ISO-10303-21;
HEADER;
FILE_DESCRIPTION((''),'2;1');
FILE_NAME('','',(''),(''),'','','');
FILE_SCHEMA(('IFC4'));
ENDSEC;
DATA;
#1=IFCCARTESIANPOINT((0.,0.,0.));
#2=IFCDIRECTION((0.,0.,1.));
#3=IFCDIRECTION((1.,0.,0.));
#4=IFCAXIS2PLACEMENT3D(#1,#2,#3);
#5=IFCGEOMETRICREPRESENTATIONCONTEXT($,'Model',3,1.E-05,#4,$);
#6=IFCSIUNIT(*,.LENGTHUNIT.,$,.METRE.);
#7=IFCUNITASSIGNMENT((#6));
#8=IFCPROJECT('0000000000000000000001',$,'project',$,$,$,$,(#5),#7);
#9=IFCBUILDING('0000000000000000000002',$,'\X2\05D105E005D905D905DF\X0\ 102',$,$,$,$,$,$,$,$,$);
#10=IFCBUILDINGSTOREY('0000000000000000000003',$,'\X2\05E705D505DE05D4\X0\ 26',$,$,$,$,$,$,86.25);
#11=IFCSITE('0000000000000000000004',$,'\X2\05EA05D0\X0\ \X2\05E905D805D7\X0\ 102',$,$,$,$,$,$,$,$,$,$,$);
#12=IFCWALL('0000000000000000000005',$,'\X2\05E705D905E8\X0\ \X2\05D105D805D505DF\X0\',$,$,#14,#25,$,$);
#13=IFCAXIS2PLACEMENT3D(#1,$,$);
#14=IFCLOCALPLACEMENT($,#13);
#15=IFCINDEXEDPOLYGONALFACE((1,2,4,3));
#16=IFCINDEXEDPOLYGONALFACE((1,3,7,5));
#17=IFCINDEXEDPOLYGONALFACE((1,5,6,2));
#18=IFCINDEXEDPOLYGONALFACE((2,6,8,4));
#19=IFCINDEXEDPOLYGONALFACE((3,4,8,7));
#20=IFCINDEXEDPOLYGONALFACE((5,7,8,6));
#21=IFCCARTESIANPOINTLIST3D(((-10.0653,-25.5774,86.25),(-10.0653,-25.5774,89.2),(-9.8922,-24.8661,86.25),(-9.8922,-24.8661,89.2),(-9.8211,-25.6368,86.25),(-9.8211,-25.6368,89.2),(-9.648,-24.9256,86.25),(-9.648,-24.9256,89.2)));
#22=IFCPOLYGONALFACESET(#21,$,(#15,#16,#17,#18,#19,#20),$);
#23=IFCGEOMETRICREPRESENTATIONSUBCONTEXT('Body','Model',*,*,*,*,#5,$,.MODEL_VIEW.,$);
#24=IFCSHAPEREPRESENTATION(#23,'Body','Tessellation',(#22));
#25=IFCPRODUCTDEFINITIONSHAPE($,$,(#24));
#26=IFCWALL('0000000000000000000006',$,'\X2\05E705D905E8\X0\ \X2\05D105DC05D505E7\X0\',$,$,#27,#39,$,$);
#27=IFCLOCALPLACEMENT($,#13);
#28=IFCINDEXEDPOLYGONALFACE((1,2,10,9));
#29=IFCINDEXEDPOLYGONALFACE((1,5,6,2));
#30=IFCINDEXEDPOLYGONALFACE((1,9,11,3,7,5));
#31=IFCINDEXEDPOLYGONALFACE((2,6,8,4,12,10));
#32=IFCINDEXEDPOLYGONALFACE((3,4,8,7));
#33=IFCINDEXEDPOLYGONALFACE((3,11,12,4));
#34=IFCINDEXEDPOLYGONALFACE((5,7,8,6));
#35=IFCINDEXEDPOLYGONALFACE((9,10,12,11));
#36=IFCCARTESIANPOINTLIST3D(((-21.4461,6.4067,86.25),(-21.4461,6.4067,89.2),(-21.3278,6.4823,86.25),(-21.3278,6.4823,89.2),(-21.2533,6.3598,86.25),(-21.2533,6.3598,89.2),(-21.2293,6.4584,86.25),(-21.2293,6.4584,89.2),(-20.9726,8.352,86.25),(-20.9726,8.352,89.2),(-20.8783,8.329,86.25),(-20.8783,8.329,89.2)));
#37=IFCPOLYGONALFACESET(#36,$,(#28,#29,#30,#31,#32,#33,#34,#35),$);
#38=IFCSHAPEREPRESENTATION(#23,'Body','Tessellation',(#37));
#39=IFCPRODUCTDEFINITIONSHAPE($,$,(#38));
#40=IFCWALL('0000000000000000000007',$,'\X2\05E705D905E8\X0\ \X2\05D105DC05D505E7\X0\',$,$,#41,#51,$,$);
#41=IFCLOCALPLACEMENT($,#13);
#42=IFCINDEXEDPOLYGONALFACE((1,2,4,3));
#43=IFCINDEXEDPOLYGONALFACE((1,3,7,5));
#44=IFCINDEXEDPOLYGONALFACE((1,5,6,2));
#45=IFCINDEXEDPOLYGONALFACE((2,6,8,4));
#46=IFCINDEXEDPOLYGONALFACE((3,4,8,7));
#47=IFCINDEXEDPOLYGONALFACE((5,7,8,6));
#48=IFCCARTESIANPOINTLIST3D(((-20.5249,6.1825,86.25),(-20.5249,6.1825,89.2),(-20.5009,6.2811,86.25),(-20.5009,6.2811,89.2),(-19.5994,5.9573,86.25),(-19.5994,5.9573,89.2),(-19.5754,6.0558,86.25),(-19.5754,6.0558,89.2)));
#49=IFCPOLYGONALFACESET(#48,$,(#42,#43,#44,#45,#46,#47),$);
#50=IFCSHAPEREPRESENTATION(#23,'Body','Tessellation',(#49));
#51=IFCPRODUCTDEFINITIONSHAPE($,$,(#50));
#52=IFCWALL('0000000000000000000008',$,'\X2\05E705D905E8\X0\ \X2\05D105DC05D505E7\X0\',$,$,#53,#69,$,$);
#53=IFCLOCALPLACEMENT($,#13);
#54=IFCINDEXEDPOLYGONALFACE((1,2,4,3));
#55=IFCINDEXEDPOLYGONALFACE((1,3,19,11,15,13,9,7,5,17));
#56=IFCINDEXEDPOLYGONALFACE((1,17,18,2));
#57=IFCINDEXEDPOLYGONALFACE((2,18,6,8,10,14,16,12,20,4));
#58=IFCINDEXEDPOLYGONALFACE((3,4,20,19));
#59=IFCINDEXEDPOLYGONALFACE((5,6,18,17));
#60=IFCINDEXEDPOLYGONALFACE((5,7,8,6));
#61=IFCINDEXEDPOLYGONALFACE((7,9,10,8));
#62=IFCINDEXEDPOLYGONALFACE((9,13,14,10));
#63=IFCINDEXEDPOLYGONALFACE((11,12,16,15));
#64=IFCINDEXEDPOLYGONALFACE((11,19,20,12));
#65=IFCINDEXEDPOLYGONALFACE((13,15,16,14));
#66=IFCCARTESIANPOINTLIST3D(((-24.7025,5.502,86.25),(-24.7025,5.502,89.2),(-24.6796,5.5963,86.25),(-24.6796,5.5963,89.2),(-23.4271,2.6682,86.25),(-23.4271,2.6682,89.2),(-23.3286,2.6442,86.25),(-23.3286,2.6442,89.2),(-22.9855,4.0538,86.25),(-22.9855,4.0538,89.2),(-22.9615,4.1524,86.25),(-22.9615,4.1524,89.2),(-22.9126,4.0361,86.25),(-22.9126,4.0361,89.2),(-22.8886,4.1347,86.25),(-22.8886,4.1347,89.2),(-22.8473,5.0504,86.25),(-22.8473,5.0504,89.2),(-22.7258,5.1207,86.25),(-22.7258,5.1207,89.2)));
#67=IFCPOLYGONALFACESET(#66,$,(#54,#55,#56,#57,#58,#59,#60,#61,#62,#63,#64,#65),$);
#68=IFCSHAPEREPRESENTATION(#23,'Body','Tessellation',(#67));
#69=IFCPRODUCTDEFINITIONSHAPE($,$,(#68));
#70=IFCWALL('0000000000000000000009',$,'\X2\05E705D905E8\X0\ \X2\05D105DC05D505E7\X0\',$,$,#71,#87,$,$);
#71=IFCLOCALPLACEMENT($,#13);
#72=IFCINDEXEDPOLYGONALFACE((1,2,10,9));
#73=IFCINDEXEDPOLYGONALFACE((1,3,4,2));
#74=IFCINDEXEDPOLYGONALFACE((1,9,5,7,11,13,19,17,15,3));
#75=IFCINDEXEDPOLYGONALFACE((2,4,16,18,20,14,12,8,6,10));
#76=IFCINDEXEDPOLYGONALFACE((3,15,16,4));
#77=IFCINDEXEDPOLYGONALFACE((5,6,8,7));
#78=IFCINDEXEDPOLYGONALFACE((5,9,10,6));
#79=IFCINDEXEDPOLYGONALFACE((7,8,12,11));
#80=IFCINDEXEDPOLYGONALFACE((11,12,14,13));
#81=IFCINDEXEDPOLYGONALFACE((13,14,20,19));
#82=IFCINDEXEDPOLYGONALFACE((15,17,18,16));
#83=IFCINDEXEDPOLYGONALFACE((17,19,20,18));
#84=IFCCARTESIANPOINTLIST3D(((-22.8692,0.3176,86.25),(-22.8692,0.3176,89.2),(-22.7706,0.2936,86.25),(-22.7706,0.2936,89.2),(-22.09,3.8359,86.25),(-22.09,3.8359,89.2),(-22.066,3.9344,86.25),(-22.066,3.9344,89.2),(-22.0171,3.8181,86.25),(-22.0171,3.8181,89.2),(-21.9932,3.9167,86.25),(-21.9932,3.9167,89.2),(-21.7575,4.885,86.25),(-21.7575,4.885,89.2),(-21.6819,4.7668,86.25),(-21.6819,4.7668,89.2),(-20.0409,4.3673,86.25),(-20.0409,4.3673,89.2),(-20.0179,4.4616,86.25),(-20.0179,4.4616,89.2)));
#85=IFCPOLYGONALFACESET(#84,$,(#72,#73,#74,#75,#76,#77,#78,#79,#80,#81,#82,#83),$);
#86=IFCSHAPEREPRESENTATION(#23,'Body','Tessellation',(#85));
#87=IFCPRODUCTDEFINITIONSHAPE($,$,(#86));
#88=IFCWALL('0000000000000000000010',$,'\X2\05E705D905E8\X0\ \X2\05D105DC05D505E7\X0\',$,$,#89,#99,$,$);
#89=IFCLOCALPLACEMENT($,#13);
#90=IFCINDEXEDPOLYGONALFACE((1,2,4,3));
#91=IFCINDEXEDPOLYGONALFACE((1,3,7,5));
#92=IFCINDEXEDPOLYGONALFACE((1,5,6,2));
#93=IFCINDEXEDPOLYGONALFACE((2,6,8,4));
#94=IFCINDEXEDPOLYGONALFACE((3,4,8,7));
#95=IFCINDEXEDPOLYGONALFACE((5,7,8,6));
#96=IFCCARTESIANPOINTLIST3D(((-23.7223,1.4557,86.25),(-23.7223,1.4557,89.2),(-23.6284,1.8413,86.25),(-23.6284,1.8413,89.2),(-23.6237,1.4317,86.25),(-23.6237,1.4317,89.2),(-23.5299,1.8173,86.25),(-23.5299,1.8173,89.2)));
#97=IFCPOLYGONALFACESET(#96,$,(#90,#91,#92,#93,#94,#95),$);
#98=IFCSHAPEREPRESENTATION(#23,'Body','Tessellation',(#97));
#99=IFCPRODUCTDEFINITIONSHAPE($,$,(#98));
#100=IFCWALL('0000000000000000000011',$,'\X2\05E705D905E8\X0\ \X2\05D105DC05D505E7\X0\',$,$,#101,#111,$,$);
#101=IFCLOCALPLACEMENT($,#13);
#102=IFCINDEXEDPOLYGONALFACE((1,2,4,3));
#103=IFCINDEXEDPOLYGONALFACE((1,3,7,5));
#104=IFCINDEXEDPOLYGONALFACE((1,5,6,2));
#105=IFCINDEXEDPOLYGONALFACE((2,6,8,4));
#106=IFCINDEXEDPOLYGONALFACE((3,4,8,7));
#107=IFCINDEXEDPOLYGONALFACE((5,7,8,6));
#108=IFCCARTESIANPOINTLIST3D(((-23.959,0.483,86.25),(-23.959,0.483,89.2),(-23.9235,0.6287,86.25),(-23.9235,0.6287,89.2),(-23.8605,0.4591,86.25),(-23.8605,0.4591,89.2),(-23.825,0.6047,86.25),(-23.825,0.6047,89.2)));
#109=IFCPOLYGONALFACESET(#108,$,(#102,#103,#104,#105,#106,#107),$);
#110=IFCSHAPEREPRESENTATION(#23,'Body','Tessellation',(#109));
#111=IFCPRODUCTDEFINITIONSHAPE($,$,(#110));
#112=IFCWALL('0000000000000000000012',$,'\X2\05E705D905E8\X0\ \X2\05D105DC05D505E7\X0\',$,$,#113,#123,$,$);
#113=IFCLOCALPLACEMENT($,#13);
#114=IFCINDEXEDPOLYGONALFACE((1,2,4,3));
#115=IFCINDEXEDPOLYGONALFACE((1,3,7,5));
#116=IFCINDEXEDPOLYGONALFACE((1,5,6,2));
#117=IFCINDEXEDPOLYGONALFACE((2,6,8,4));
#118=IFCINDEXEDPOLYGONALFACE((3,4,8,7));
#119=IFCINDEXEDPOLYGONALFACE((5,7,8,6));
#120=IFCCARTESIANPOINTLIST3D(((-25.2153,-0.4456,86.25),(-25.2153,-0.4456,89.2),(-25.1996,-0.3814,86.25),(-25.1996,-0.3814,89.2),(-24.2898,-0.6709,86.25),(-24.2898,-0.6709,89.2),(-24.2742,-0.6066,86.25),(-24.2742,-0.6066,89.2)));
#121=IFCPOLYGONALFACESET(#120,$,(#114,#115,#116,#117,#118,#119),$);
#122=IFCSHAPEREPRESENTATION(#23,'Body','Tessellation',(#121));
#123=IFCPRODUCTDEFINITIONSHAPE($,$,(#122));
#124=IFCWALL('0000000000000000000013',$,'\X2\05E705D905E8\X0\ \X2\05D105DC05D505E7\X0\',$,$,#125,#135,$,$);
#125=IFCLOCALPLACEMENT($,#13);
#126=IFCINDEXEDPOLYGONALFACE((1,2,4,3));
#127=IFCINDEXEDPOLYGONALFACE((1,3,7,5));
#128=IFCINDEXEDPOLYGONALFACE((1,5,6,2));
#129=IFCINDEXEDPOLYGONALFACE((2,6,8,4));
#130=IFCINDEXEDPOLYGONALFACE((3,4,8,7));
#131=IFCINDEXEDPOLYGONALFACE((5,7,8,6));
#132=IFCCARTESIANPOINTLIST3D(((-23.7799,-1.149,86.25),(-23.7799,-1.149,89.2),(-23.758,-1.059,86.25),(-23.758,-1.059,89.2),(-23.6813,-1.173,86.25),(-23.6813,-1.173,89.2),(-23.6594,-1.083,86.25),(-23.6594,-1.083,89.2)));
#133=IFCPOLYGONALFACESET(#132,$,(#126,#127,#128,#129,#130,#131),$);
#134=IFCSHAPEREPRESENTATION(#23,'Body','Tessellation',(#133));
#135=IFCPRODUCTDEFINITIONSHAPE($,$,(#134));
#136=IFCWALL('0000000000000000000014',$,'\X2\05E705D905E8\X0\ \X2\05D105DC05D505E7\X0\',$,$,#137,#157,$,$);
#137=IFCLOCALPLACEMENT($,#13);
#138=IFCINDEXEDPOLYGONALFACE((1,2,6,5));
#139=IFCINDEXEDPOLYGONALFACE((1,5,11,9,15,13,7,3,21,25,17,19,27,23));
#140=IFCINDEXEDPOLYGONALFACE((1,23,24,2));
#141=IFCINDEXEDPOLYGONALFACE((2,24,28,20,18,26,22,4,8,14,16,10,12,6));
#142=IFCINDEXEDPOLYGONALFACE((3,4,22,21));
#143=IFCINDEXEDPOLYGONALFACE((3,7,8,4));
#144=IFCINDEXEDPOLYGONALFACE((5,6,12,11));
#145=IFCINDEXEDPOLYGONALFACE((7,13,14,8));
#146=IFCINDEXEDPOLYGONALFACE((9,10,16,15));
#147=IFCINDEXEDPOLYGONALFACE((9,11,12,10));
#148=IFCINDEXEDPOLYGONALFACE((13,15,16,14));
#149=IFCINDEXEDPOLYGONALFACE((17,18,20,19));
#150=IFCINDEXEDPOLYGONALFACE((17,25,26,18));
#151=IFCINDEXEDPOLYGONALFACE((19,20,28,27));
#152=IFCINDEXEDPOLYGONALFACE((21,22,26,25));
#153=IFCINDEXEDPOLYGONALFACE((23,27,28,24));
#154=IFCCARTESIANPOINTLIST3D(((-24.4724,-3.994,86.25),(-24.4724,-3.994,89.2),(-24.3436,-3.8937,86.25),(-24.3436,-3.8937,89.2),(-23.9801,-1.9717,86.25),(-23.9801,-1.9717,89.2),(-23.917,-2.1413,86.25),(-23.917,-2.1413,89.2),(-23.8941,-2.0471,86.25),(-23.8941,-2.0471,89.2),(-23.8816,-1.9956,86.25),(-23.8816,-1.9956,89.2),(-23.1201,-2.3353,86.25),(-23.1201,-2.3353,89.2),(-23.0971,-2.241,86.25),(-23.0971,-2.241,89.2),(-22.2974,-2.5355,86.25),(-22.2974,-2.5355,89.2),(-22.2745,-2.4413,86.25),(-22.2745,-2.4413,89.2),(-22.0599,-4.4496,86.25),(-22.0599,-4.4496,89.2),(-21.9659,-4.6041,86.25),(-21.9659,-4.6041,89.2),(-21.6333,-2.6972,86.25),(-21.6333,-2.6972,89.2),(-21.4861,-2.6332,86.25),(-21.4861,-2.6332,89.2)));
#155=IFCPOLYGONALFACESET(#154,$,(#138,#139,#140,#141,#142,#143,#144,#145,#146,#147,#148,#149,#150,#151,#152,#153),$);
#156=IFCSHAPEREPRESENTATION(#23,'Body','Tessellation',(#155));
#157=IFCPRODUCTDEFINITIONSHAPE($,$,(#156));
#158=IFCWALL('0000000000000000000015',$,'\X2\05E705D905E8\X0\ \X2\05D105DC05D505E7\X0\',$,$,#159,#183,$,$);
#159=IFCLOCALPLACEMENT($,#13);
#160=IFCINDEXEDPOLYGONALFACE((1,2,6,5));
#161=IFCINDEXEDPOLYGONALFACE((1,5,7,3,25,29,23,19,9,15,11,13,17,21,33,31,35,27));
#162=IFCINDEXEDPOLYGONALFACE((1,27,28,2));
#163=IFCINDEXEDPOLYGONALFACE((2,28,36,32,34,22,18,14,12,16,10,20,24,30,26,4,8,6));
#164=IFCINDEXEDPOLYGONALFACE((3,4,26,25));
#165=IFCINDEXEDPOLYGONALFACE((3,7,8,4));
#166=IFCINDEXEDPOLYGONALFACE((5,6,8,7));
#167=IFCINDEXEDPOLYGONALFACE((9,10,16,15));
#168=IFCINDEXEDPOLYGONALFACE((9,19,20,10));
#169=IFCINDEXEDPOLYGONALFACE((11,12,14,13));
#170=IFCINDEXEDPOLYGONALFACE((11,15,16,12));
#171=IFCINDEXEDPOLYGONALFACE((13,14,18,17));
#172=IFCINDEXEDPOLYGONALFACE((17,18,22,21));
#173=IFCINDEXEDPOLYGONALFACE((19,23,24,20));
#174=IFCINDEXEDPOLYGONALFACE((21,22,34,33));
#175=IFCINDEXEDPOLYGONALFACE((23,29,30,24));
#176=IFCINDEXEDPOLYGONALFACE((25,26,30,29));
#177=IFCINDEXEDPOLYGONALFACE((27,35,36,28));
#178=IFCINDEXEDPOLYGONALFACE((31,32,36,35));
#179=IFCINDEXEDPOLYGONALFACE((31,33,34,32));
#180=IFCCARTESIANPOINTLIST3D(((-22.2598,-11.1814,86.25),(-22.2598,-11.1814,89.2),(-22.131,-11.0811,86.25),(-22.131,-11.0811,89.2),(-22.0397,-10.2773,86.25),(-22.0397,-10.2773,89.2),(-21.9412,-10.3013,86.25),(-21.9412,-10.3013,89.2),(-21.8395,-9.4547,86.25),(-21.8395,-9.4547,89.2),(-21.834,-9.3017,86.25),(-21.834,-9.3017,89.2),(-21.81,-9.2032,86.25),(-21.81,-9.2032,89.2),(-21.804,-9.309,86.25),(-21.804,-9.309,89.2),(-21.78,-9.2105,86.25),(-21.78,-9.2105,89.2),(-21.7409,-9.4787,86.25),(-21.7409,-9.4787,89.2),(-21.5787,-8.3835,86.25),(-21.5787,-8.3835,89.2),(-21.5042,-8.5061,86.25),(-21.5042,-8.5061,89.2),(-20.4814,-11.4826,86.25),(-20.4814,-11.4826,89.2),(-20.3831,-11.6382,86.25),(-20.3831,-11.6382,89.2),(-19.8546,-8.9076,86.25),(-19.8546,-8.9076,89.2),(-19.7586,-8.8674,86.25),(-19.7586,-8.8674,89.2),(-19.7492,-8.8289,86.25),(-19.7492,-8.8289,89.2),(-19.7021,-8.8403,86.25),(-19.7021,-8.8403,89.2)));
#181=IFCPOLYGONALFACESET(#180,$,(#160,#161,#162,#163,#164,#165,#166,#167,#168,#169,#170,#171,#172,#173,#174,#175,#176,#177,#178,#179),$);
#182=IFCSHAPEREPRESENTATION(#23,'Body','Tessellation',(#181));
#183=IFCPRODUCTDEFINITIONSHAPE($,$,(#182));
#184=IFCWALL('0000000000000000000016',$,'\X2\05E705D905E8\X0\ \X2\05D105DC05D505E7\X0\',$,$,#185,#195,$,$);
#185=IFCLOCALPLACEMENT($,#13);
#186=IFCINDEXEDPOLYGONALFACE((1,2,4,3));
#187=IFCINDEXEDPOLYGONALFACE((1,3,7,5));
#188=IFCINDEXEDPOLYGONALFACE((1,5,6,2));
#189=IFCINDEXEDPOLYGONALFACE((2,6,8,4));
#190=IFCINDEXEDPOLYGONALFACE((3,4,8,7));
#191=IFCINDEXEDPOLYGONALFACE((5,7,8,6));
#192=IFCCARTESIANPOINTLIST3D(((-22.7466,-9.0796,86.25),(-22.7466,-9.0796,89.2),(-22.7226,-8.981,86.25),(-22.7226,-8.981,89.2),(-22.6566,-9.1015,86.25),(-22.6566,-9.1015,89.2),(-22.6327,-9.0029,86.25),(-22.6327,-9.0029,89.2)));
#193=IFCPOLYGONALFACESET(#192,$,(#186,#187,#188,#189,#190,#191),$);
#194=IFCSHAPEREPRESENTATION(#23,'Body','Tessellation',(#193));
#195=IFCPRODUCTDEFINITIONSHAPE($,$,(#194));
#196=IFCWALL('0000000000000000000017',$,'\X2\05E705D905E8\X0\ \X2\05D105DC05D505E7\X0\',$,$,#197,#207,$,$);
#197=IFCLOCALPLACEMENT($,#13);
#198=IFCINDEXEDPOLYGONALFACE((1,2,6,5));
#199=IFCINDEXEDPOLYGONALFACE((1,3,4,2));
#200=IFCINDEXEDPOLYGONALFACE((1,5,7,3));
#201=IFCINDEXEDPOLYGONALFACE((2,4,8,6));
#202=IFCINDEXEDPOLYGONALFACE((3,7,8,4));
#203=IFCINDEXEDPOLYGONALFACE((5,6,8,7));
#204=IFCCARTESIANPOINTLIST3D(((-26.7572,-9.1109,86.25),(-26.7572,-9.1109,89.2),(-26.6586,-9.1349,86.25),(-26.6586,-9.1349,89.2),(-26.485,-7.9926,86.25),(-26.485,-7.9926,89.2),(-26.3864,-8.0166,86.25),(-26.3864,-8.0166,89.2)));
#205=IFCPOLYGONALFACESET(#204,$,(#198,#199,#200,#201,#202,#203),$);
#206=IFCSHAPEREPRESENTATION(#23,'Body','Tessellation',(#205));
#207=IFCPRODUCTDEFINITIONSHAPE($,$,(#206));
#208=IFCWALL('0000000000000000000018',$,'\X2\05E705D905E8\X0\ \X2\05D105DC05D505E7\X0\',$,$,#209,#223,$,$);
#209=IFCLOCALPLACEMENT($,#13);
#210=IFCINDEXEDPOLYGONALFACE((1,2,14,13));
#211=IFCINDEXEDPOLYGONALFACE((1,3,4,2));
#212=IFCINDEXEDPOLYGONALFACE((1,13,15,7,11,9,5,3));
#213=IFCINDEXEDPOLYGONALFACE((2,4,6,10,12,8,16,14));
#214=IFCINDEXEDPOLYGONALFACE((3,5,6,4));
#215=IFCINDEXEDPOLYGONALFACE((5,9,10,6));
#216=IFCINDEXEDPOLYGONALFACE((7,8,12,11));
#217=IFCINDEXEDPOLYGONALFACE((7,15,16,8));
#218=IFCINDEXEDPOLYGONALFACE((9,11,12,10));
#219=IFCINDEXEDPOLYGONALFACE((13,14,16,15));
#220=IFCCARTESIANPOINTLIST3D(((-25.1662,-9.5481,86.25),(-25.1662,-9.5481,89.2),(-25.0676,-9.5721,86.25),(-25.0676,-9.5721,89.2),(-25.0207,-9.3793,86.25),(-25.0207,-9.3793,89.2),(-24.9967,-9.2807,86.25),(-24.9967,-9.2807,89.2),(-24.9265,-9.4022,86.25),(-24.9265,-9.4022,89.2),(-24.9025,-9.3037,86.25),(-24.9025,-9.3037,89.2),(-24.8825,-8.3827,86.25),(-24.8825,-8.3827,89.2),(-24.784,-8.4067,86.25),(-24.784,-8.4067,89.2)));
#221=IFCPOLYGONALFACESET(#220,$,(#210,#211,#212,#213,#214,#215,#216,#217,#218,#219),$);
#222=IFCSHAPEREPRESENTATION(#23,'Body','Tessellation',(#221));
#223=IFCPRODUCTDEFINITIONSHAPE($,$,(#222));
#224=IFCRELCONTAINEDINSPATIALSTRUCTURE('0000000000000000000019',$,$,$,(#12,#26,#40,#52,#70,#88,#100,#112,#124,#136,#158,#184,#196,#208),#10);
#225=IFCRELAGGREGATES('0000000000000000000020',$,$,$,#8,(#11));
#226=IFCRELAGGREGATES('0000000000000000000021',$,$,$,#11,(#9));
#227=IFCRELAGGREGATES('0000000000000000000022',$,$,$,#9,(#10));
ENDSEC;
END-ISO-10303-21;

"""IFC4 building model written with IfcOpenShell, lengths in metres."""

from ifc_helpers import new_model, si_unit, frame, origin_with_axes, context, subcontext, project, spatial, polyline, outline, extrude, element, save


model = new_model("IFC4")

# Units and contexts
model_context = context("Model", 3, precision=1e-05, world=origin_with_axes())
body_context = subcontext(model_context, "Body", "Model", "MODEL_VIEW")
ifc_project = project(units=[si_unit("LENGTHUNIT", "METRE")], contexts=[model_context])

# Site, building, storey
site = spatial("IfcSite", under=ifc_project, Name="תא שטח 102")
building = spatial("IfcBuilding", under=site, Name="בניין 102")
storey = spatial("IfcBuildingStorey", under=building, Name="קומה 26", Elevation=86.25)

# Walls
element("IfcWall", 1, inside=storey, Name="קיר בטון", context=body_context, shape_type="SweptSolid", body=[
    extrude(outline(polyline([(-10.0653, -25.5774), (-9.8211, -25.6368), (-9.648, -24.9256), (-9.8922, -24.8661), (-10.0653, -25.5774)])), frame((0.0, 0.0, 86.25)), (0.0, 0.0, 1.0), 2.95),
])
element("IfcWall", 2, inside=storey, Name="קיר בלוק", context=body_context, shape_type="SweptSolid", body=[
    extrude(outline(polyline([(-21.4461, 6.4067), (-21.2533, 6.3598), (-21.2293, 6.4584), (-21.3278, 6.4823), (-20.8783, 8.329), (-20.9726, 8.352), (-21.4461, 6.4067)])), frame((0.0, 0.0, 86.25)), (0.0, 0.0, 1.0), 2.95),
])
element("IfcWall", 3, inside=storey, Name="קיר בלוק", context=body_context, shape_type="SweptSolid", body=[
    extrude(outline(polyline([(-19.5754, 6.0558), (-20.5009, 6.2811), (-20.5249, 6.1825), (-19.5994, 5.9573), (-19.5754, 6.0558)])), frame((0.0, 0.0, 86.25)), (0.0, 0.0, 1.0), 2.95),
])
element("IfcWall", 4, inside=storey, Name="קיר בלוק", context=body_context, shape_type="SweptSolid", body=[
    extrude(outline(polyline([(-23.4271, 2.6682), (-23.3286, 2.6442), (-22.9855, 4.0538), (-22.9126, 4.0361), (-22.8886, 4.1347), (-22.9615, 4.1524), (-22.7258, 5.1207), (-24.6796, 5.5963), (-24.7025, 5.502), (-22.8473, 5.0504), (-23.4271, 2.6682)])), frame((0.0, 0.0, 86.25)), (0.0, 0.0, 1.0), 2.95),
])
element("IfcWall", 5, inside=storey, Name="קיר בלוק", context=body_context, shape_type="SweptSolid", body=[
    extrude(outline(polyline([(-22.09, 3.8359), (-22.0171, 3.8181), (-22.8692, 0.3176), (-22.7706, 0.2936), (-21.6819, 4.7668), (-20.0409, 4.3673), (-20.0179, 4.4616), (-21.7575, 4.885), (-21.9932, 3.9167), (-22.066, 3.9344), (-22.09, 3.8359)])), frame((0.0, 0.0, 86.25)), (0.0, 0.0, 1.0), 2.95),
])
element("IfcWall", 6, inside=storey, Name="קיר בלוק", context=body_context, shape_type="SweptSolid", body=[
    extrude(outline(polyline([(-23.5299, 1.8173), (-23.6284, 1.8413), (-23.7223, 1.4557), (-23.6237, 1.4317), (-23.5299, 1.8173)])), frame((0.0, 0.0, 86.25)), (0.0, 0.0, 1.0), 2.95),
])
element("IfcWall", 7, inside=storey, Name="קיר בלוק", context=body_context, shape_type="SweptSolid", body=[
    extrude(outline(polyline([(-23.9235, 0.6287), (-23.959, 0.483), (-23.8605, 0.4591), (-23.825, 0.6047), (-23.9235, 0.6287)])), frame((0.0, 0.0, 86.25)), (0.0, 0.0, 1.0), 2.95),
])
element("IfcWall", 8, inside=storey, Name="קיר בלוק", context=body_context, shape_type="SweptSolid", body=[
    extrude(outline(polyline([(-25.1996, -0.3814), (-25.2153, -0.4456), (-24.2898, -0.6709), (-24.2742, -0.6066), (-25.1996, -0.3814)])), frame((0.0, 0.0, 86.25)), (0.0, 0.0, 1.0), 2.95),
])
element("IfcWall", 9, inside=storey, Name="קיר בלוק", context=body_context, shape_type="SweptSolid", body=[
    extrude(outline(polyline([(-23.6594, -1.083), (-23.758, -1.059), (-23.7799, -1.149), (-23.6813, -1.173), (-23.6594, -1.083)])), frame((0.0, 0.0, 86.25)), (0.0, 0.0, 1.0), 2.95),
])
element("IfcWall", 10, inside=storey, Name="קיר בלוק", context=body_context, shape_type="SweptSolid", body=[
    extrude(outline(polyline([(-24.3436, -3.8937), (-23.917, -2.1413), (-23.1201, -2.3353), (-23.0971, -2.241), (-23.8941, -2.0471), (-23.8816, -1.9956), (-23.9801, -1.9717), (-24.4724, -3.994), (-21.9659, -4.6041), (-21.4861, -2.6332), (-22.2745, -2.4413), (-22.2974, -2.5355), (-21.6333, -2.6972), (-22.0599, -4.4496), (-24.3436, -3.8937)])), frame((0.0, 0.0, 86.25)), (0.0, 0.0, 1.0), 2.95),
])
element("IfcWall", 11, inside=storey, Name="קיר בלוק", context=body_context, shape_type="SweptSolid", body=[
    extrude(outline(polyline([(-21.81, -9.2032), (-21.834, -9.3017), (-21.804, -9.309), (-21.8395, -9.4547), (-21.7409, -9.4787), (-21.5042, -8.5061), (-19.8546, -8.9076), (-20.4814, -11.4826), (-22.131, -11.0811), (-21.9412, -10.3013), (-22.0397, -10.2773), (-22.2598, -11.1814), (-20.3831, -11.6382), (-19.7021, -8.8403), (-19.7586, -8.8674), (-19.7492, -8.8289), (-21.5787, -8.3835), (-21.78, -9.2105), (-21.81, -9.2032)])), frame((0.0, 0.0, 86.25)), (0.0, 0.0, 1.0), 2.95),
])
element("IfcWall", 12, inside=storey, Name="קיר בלוק", context=body_context, shape_type="SweptSolid", body=[
    extrude(outline(polyline([(-22.7226, -8.981), (-22.7466, -9.0796), (-22.6566, -9.1015), (-22.6327, -9.0029), (-22.7226, -8.981)])), frame((0.0, 0.0, 86.25)), (0.0, 0.0, 1.0), 2.95),
])
element("IfcWall", 13, inside=storey, Name="קיר בלוק", context=body_context, shape_type="SweptSolid", body=[
    extrude(outline(polyline([(-26.7572, -9.1109), (-26.6586, -9.1349), (-26.3864, -8.0166), (-26.485, -7.9926), (-26.7572, -9.1109)])), frame((0.0, 0.0, 86.25)), (0.0, 0.0, 1.0), 2.95),
])
element("IfcWall", 14, inside=storey, Name="קיר בלוק", context=body_context, shape_type="SweptSolid", body=[
    extrude(outline(polyline([(-24.9025, -9.3037), (-24.9967, -9.2807), (-24.784, -8.4067), (-24.8825, -8.3827), (-25.1662, -9.5481), (-25.0676, -9.5721), (-25.0207, -9.3793), (-24.9265, -9.4022), (-24.9025, -9.3037)])), frame((0.0, 0.0, 86.25)), (0.0, 0.0, 1.0), 2.95),
])

save(model, "model.ifc")
